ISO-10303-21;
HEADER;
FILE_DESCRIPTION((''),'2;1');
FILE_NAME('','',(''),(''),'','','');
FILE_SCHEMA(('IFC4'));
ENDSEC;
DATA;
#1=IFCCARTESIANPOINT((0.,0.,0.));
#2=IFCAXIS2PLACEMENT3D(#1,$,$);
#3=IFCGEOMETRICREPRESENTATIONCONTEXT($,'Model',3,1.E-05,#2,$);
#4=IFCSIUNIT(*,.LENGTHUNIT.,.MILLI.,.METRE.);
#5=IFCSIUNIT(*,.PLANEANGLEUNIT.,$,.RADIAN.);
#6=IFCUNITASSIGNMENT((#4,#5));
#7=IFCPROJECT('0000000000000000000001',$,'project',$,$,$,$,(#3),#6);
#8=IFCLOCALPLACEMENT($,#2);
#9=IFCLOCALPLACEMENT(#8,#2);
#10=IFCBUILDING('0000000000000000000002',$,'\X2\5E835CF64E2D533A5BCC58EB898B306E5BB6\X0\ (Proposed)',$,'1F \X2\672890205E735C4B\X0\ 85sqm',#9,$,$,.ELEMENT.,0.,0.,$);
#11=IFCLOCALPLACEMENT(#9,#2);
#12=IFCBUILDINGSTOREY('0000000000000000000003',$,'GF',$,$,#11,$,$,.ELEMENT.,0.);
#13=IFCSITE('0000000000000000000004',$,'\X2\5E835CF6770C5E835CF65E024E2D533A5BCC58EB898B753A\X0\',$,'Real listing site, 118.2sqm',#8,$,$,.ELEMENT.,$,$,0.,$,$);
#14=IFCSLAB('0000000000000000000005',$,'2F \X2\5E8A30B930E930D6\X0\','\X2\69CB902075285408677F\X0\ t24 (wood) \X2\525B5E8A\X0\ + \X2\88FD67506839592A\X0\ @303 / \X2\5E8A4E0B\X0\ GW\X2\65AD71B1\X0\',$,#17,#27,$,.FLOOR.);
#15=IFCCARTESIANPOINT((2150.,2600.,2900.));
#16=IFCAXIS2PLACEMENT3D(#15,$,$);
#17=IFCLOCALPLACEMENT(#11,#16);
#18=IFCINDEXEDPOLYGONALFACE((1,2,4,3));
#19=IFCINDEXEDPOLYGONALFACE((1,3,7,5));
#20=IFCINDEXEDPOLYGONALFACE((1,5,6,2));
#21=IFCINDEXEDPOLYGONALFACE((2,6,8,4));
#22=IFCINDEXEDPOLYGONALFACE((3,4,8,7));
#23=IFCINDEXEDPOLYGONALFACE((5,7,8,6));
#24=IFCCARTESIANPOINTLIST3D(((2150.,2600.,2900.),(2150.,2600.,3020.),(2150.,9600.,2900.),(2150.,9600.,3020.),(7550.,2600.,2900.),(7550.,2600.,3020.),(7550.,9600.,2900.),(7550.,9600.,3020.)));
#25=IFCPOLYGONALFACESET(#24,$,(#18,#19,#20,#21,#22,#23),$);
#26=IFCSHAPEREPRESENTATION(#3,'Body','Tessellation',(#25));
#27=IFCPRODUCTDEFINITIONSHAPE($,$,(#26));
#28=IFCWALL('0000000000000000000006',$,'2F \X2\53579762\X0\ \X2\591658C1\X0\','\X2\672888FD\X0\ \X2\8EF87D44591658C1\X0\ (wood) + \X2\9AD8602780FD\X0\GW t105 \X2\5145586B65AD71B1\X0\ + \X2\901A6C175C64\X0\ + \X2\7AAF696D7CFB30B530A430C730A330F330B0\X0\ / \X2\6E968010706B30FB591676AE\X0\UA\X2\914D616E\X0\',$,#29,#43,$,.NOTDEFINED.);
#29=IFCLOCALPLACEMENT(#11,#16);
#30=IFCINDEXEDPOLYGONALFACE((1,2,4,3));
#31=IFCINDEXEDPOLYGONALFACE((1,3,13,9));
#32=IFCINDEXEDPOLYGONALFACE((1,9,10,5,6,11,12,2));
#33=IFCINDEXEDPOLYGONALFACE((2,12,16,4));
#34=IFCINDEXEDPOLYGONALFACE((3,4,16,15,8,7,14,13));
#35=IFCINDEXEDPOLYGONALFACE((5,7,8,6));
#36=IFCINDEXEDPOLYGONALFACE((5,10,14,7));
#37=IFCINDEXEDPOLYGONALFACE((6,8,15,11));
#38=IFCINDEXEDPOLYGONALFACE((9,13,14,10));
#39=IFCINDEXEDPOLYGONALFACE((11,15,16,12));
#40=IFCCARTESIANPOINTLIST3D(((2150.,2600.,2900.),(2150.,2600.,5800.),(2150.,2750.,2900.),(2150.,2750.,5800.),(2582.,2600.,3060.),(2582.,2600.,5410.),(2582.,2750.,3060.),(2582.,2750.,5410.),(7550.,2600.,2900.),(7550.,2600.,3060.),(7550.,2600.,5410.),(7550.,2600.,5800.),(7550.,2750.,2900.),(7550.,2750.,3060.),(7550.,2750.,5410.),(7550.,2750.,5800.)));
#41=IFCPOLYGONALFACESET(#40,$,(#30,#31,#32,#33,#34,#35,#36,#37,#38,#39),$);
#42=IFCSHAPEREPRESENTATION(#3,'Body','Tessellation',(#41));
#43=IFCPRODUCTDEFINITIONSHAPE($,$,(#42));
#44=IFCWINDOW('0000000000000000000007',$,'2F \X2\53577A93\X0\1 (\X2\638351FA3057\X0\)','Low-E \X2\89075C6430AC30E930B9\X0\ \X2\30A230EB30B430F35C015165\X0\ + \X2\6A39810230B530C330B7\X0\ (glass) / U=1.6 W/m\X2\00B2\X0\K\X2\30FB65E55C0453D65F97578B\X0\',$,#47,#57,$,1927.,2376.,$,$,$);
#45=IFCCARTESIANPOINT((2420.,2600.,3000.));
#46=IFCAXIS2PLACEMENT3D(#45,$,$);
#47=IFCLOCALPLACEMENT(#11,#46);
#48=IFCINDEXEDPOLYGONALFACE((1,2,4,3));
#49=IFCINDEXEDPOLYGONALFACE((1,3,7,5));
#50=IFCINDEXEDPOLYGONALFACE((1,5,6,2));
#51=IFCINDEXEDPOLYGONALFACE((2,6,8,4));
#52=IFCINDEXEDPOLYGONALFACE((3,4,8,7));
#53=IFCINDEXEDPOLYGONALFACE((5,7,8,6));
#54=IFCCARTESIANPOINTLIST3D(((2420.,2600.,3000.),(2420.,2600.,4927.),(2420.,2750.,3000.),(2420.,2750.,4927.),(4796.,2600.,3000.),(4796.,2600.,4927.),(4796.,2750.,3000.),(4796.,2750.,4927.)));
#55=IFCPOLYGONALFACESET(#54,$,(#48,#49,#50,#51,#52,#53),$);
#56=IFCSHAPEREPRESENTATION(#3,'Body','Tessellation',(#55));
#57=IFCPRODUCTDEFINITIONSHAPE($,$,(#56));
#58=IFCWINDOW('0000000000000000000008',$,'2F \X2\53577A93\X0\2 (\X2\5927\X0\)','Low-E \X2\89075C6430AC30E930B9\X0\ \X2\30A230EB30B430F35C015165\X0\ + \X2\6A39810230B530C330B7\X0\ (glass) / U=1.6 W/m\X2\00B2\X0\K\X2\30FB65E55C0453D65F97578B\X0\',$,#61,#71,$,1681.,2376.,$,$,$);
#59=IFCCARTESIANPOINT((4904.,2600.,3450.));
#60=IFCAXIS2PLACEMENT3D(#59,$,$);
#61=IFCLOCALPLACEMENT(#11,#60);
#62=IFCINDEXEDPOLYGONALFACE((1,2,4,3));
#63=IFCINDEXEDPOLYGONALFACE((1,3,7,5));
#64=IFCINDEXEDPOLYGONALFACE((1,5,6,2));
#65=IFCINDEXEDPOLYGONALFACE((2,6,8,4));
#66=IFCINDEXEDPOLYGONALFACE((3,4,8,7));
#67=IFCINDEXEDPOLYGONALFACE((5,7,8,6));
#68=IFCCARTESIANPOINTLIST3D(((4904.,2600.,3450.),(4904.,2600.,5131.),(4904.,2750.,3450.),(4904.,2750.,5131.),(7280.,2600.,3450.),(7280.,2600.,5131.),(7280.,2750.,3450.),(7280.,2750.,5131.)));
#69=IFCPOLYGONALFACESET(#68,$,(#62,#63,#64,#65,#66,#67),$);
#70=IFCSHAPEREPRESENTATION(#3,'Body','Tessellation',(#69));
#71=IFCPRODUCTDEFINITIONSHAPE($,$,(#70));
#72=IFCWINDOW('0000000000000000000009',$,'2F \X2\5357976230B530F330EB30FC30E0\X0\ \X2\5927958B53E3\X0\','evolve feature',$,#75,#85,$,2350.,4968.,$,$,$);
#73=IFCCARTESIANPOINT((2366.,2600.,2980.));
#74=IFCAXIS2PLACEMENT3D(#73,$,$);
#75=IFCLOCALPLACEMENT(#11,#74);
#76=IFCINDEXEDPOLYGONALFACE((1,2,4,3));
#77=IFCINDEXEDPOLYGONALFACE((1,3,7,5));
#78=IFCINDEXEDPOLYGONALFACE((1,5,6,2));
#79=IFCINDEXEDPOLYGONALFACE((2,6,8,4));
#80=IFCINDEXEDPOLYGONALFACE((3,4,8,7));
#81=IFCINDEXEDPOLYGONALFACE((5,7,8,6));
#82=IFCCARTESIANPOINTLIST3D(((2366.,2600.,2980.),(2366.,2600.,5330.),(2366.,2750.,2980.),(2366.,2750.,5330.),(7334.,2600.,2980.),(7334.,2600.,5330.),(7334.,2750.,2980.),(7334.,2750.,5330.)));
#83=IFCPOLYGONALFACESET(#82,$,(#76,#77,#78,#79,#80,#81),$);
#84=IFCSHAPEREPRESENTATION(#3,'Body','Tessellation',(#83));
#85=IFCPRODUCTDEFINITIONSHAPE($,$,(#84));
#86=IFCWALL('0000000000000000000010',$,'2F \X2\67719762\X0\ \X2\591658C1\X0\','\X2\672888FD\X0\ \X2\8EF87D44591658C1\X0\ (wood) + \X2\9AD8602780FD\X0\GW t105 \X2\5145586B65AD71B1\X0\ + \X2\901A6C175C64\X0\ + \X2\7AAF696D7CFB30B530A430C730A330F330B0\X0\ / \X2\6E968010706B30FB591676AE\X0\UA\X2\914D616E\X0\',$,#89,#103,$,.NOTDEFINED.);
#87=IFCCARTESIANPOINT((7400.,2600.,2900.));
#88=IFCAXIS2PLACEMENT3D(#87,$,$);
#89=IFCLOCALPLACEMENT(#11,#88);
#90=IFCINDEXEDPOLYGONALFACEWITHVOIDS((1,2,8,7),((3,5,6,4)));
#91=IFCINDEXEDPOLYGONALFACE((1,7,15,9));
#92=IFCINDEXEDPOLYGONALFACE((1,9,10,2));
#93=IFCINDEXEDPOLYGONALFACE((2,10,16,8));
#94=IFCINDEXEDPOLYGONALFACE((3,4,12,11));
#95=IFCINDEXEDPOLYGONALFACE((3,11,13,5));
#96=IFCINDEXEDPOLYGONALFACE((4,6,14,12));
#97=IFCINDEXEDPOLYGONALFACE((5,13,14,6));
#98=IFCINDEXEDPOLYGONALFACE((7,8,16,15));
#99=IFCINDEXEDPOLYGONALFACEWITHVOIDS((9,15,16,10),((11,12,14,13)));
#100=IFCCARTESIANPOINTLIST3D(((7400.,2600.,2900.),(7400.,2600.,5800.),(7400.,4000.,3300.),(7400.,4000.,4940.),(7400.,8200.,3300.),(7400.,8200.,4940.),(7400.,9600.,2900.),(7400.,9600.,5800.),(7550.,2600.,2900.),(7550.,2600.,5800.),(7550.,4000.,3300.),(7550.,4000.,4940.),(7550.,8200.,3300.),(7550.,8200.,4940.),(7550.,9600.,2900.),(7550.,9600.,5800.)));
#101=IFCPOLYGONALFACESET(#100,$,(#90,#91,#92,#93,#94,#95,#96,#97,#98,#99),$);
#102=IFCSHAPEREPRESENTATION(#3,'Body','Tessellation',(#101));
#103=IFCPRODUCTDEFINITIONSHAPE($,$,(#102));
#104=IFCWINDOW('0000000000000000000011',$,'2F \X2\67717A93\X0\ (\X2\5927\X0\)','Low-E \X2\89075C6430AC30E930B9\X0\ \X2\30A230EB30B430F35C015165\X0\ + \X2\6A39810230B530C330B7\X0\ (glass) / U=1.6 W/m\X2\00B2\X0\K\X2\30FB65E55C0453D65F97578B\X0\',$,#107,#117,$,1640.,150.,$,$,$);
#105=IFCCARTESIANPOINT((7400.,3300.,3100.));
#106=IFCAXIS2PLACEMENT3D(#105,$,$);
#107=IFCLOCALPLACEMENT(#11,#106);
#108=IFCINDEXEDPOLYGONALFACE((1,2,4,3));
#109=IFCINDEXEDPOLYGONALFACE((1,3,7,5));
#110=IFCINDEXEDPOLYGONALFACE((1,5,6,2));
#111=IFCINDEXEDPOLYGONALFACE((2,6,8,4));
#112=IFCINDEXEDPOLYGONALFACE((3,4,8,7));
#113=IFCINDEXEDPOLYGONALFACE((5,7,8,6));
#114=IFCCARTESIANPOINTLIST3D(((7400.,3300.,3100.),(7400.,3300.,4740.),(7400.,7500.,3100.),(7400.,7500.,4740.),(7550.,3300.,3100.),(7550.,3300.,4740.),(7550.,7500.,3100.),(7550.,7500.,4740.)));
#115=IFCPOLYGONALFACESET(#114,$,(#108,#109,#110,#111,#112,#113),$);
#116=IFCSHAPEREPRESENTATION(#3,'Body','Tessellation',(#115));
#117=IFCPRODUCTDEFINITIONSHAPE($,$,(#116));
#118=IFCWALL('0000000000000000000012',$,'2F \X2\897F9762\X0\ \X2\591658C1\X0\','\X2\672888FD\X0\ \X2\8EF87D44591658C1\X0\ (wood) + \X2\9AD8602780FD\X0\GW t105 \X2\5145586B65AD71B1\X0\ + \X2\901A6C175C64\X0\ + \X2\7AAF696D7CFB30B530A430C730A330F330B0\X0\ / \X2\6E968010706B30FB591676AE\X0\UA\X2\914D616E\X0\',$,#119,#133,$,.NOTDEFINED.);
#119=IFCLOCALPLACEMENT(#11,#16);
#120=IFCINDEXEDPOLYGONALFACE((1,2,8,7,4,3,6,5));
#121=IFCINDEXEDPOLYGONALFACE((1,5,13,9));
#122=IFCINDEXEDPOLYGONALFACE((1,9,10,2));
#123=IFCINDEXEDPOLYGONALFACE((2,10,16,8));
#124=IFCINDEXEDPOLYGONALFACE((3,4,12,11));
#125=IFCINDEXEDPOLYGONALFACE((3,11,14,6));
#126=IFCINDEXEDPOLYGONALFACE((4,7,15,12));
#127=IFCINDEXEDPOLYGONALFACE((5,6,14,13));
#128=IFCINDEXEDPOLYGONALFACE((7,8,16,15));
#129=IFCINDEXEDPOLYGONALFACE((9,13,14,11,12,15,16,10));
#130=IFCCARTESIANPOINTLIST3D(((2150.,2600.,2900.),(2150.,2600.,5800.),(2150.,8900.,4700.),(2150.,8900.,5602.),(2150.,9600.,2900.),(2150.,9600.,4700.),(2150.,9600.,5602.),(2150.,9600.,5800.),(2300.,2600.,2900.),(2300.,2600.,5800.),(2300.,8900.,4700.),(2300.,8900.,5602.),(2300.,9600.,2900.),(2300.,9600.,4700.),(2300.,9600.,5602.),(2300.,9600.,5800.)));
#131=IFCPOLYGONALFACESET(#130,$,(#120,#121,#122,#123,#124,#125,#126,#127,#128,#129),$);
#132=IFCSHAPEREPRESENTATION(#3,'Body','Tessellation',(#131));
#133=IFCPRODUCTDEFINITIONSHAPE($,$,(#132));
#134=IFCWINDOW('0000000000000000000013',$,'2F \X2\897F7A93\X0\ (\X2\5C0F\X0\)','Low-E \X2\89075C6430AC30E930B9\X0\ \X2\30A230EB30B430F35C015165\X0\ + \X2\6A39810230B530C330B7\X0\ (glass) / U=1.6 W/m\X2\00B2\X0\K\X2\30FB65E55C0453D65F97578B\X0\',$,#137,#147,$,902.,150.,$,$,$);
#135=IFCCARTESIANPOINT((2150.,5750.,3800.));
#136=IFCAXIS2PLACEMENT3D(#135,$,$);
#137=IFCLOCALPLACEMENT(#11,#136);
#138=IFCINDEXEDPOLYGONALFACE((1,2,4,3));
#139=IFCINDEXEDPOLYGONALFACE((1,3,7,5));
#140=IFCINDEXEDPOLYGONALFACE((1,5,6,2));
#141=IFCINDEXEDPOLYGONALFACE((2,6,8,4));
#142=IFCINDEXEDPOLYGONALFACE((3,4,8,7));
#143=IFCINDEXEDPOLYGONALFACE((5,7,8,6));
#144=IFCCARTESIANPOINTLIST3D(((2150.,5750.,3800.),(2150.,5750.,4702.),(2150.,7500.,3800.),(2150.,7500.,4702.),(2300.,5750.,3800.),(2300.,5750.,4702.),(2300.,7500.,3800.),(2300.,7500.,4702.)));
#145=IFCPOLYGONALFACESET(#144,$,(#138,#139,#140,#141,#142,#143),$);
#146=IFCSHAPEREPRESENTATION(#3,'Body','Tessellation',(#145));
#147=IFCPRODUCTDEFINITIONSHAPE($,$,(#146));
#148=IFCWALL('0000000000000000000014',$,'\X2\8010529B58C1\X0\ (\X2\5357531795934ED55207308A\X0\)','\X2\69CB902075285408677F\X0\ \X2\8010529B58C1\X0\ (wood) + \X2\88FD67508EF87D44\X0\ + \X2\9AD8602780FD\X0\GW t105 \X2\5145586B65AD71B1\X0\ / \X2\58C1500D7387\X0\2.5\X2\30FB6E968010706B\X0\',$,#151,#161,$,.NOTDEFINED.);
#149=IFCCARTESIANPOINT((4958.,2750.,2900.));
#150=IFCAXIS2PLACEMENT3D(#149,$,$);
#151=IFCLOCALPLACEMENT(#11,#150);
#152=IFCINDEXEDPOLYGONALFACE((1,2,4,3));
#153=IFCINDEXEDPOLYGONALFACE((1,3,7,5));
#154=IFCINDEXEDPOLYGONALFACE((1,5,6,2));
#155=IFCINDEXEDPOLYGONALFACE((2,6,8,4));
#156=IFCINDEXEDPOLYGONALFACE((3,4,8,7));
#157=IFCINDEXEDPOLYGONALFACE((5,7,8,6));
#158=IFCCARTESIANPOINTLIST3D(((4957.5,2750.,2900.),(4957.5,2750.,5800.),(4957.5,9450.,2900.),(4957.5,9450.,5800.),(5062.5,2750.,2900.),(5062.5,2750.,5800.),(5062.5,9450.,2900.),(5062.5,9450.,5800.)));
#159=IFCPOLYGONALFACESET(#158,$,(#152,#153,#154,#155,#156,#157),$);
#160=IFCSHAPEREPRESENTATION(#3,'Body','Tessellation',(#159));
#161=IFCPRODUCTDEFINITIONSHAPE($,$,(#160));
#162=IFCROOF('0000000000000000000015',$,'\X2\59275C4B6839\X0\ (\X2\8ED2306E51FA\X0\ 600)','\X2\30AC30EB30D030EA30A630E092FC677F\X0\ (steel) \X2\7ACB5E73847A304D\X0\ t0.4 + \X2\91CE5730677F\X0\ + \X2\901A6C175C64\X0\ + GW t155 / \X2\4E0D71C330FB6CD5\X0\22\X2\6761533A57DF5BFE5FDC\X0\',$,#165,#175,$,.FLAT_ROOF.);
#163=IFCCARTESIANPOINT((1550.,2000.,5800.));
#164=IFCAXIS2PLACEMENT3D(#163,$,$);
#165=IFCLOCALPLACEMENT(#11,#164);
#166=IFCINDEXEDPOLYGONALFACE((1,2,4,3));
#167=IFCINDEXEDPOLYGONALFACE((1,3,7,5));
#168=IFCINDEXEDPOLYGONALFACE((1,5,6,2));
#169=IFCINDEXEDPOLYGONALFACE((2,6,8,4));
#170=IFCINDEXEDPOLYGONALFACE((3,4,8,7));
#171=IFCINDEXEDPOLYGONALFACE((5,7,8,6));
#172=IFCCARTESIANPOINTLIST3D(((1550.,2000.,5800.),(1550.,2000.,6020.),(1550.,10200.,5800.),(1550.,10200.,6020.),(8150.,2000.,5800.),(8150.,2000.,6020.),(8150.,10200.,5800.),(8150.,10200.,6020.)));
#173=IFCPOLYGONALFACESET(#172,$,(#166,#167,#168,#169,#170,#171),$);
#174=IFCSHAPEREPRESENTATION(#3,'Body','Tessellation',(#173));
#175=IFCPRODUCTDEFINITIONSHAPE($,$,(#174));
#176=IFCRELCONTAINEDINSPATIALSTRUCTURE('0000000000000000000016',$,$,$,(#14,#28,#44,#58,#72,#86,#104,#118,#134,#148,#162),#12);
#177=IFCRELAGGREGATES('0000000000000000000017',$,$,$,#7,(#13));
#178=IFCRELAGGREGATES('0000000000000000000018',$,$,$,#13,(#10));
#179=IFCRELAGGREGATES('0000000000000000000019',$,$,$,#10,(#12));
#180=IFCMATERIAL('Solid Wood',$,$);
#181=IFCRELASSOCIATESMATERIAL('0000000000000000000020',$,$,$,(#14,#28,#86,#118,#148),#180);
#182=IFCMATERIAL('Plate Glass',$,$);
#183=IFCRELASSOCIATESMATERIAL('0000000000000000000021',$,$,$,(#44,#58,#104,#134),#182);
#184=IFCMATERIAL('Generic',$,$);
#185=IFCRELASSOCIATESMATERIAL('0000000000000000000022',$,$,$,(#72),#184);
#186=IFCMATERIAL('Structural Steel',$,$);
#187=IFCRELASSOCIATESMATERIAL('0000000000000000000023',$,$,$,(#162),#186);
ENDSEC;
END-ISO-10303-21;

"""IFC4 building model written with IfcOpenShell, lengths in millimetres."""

from ifc_helpers import new_model, si_unit, frame, frame_2d, origin, place, context, project, spatial, rectangle, extrude, material, element, fill, save


model = new_model("IFC4")

# Units and contexts
model_context = context("Model", 3, precision=1e-05, world=origin())
ifc_project = project(units=[si_unit("LENGTHUNIT", "METRE", prefix="MILLI"), si_unit("PLANEANGLEUNIT", "RADIAN")], contexts=[model_context])

# Site, building, storey
site_placement = place(None, origin())
site = spatial("IfcSite", under=ifc_project, at=site_placement, Name="広島県広島市中区富士見町", ObjectType="Real listing site, 118.2sqm", CompositionType="ELEMENT", RefElevation=0.0)
building_placement = place(site_placement, origin())
building = spatial("IfcBuilding", under=site, at=building_placement, Name="広島中区富士見の家 (Proposed)", ObjectType="1F 木造平屋 85sqm", CompositionType="ELEMENT", ElevationOfRefHeight=0.0, ElevationOfTerrain=0.0)
storey_placement = place(building_placement, origin())
storey = spatial("IfcBuildingStorey", under=building, at=storey_placement, Name="GF", CompositionType="ELEMENT", Elevation=0.0)

# Slab
ifc_material_1 = material(Name="Solid Wood")
slab_placement = place(storey_placement, frame((2150.0, 2600.0, 2900.0)))
element("IfcSlab", 1, at=slab_placement, inside=storey, material=ifc_material_1, Name="2F 床スラブ", Description="構造用合板 t24 (wood) 剛床 + 製材根太 @303 / 床下 GW断熱", PredefinedType="FLOOR", context=model_context, shape_type="SweptSolid", body=[
    extrude(rectangle(XDim=5400.0, YDim=7000.0, at=frame_2d((2700.0, 3500.0))), frame((2150.0, 2600.0, 2900.0)), (0.0, 0.0, 1.0), 120.0),
])

# Wall, openings, windows
wall_1_placement = place(storey_placement, frame((2150.0, 2600.0, 2900.0)))
wall_1 = element("IfcWall", 2, at=wall_1_placement, inside=storey, material=ifc_material_1, Name="2F 南面 外壁", Description="木製 軸組外壁 (wood) + 高性能GW t105 充填断熱 + 通気層 + 窯業系サイディング / 準耐火・外皮UA配慮", PredefinedType="NOTDEFINED", context=model_context, shape_type="SweptSolid", body=[
    extrude(rectangle(XDim=5400.0, YDim=150.0, at=frame_2d((2700.0, 75.0))), frame((2150.0, 2600.0, 2900.0)), (0.0, 0.0, 1.0), 2900.0),
])
opening_1_placement = place(storey_placement, frame((2420.0, 2600.0, 3000.0)))
opening_1 = element("IfcOpeningElement", 3, at=opening_1_placement, cuts=wall_1, PredefinedType="NOTDEFINED", context=model_context, shape_type="SweptSolid", body=[
    extrude(rectangle(XDim=2376.0, YDim=150.0, at=frame_2d((1188.0, 75.0))), frame((2420.0, 2600.0, 3000.0)), (0.0, 0.0, 1.0), 1927.0),
])
opening_2_placement = place(storey_placement, frame((4904.0, 2600.0, 3450.0)))
opening_2 = element("IfcOpeningElement", 4, at=opening_2_placement, cuts=wall_1, PredefinedType="NOTDEFINED", context=model_context, shape_type="SweptSolid", body=[
    extrude(rectangle(XDim=2376.0, YDim=150.0, at=frame_2d((1188.0, 75.0))), frame((4904.0, 2600.0, 3450.0)), (0.0, 0.0, 1.0), 1681.0),
])
opening_3_placement = place(storey_placement, frame((2366.0, 2600.0, 2980.0)))
opening_3 = element("IfcOpeningElement", 5, at=opening_3_placement, cuts=wall_1, PredefinedType="NOTDEFINED", context=model_context, shape_type="SweptSolid", body=[
    extrude(rectangle(XDim=4968.0, YDim=150.0, at=frame_2d((2484.0, 75.0))), frame((2366.0, 2600.0, 2980.0)), (0.0, 0.0, 1.0), 2350.0),
])
ifc_material_2 = material(Name="Plate Glass")
window_1_placement = place(storey_placement, frame((2420.0, 2600.0, 3000.0)))
window_1 = element("IfcWindow", 6, at=window_1_placement, inside=storey, material=ifc_material_2, Name="2F 南窓1 (掃出し)", Description="Low-E 複層ガラス アルゴン封入 + 樹脂サッシ (glass) / U=1.6 W/m²K・日射取得型", OverallHeight=1927.0, OverallWidth=2376.0, context=model_context, shape_type="SweptSolid", body=[
    extrude(rectangle(XDim=2376.0, YDim=150.0, at=frame_2d((1188.0, 75.0))), frame((2420.0, 2600.0, 3000.0)), (0.0, 0.0, 1.0), 1927.0),
])
fill(opening_1, window_1)
window_2_placement = place(storey_placement, frame((4904.0, 2600.0, 3450.0)))
window_2 = element("IfcWindow", 7, at=window_2_placement, inside=storey, material=ifc_material_2, Name="2F 南窓2 (大)", Description="Low-E 複層ガラス アルゴン封入 + 樹脂サッシ (glass) / U=1.6 W/m²K・日射取得型", OverallHeight=1681.0, OverallWidth=2376.0, context=model_context, shape_type="SweptSolid", body=[
    extrude(rectangle(XDim=2376.0, YDim=150.0, at=frame_2d((1188.0, 75.0))), frame((4904.0, 2600.0, 3450.0)), (0.0, 0.0, 1.0), 1681.0),
])
fill(opening_2, window_2)
ifc_material_3 = material(Name="Generic")
window_3_placement = place(storey_placement, frame((2366.0, 2600.0, 2980.0)))
window_3 = element("IfcWindow", 8, at=window_3_placement, inside=storey, material=ifc_material_3, Name="2F 南面サンルーム 大開口", Description="evolve feature", OverallHeight=2350.0, OverallWidth=4968.0, context=model_context, shape_type="SweptSolid", body=[
    extrude(rectangle(XDim=4968.0, YDim=150.0, at=frame_2d((2484.0, 75.0))), frame((2366.0, 2600.0, 2980.0)), (0.0, 0.0, 1.0), 2350.0),
])
fill(opening_3, window_3)

# Walls, openings, windows
wall_2_placement = place(storey_placement, frame((7400.0, 2600.0, 2900.0)))
wall_2 = element("IfcWall", 9, at=wall_2_placement, inside=storey, material=ifc_material_1, Name="2F 東面 外壁", Description="木製 軸組外壁 (wood) + 高性能GW t105 充填断熱 + 通気層 + 窯業系サイディング / 準耐火・外皮UA配慮", PredefinedType="NOTDEFINED", context=model_context, shape_type="SweptSolid", body=[
    extrude(rectangle(XDim=150.0, YDim=7000.0, at=frame_2d((75.0, 3500.0))), frame((7400.0, 2600.0, 2900.0)), (0.0, 0.0, 1.0), 2900.0),
])
opening_4_placement = place(storey_placement, frame((7400.0, 3300.0, 3100.0)))
opening_4 = element("IfcOpeningElement", 10, at=opening_4_placement, cuts=wall_2, PredefinedType="NOTDEFINED", context=model_context, shape_type="SweptSolid", body=[
    extrude(rectangle(XDim=150.0, YDim=4200.0, at=frame_2d((75.0, 2100.0))), frame((7400.0, 3300.0, 3100.0)), (0.0, 0.0, 1.0), 1640.0),
])
window_4_placement = place(storey_placement, frame((7400.0, 3300.0, 3100.0)))
window_4 = element("IfcWindow", 11, at=window_4_placement, inside=storey, material=ifc_material_2, Name="2F 東窓 (大)", Description="Low-E 複層ガラス アルゴン封入 + 樹脂サッシ (glass) / U=1.6 W/m²K・日射取得型", OverallHeight=1640.0, OverallWidth=150.0, context=model_context, shape_type="SweptSolid", body=[
    extrude(rectangle(XDim=150.0, YDim=4200.0, at=frame_2d((75.0, 2100.0))), frame((7400.0, 3300.0, 3100.0)), (0.0, 0.0, 1.0), 1640.0),
])
fill(opening_4, window_4)
wall_3_placement = place(storey_placement, frame((2150.0, 2600.0, 2900.0)))
wall_3 = element("IfcWall", 12, at=wall_3_placement, inside=storey, material=ifc_material_1, Name="2F 西面 外壁", Description="木製 軸組外壁 (wood) + 高性能GW t105 充填断熱 + 通気層 + 窯業系サイディング / 準耐火・外皮UA配慮", PredefinedType="NOTDEFINED", context=model_context, shape_type="SweptSolid", body=[
    extrude(rectangle(XDim=150.0, YDim=7000.0, at=frame_2d((75.0, 3500.0))), frame((2150.0, 2600.0, 2900.0)), (0.0, 0.0, 1.0), 2900.0),
])
opening_5_placement = place(storey_placement, frame((2150.0, 5750.0, 3800.0)))
opening_5 = element("IfcOpeningElement", 13, at=opening_5_placement, cuts=wall_3, PredefinedType="NOTDEFINED", context=model_context, shape_type="SweptSolid", body=[
    extrude(rectangle(XDim=150.0, YDim=1750.0, at=frame_2d((75.0, 875.0))), frame((2150.0, 5750.0, 3800.0)), (0.0, 0.0, 1.0), 902.0),
])
window_5_placement = place(storey_placement, frame((2150.0, 5750.0, 3800.0)))
window_5 = element("IfcWindow", 14, at=window_5_placement, inside=storey, material=ifc_material_2, Name="2F 西窓 (小)", Description="Low-E 複層ガラス アルゴン封入 + 樹脂サッシ (glass) / U=1.6 W/m²K・日射取得型", OverallHeight=902.0, OverallWidth=150.0, context=model_context, shape_type="SweptSolid", body=[
    extrude(rectangle(XDim=150.0, YDim=1750.0, at=frame_2d((75.0, 875.0))), frame((2150.0, 5750.0, 3800.0)), (0.0, 0.0, 1.0), 902.0),
])
fill(opening_5, window_5)

# Wall
wall_4_placement = place(storey_placement, frame((4958.0, 2750.0, 2900.0)))
element("IfcWall", 15, at=wall_4_placement, inside=storey, material=ifc_material_1, Name="耐力壁 (南北間仕切り)", Description="構造用合板 耐力壁 (wood) + 製材軸組 + 高性能GW t105 充填断熱 / 壁倍率2.5・準耐火", PredefinedType="NOTDEFINED", context=model_context, shape_type="SweptSolid", body=[
    extrude(rectangle(XDim=105.0, YDim=6700.0, at=frame_2d((52.0, 3350.0))), frame((4958.0, 2750.0, 2900.0)), (0.0, 0.0, 1.0), 2900.0),
])

# Roof
ifc_material_4 = material(Name="Structural Steel")
roof_1_placement = place(storey_placement, frame((1550.0, 2000.0, 5800.0)))
element("IfcRoof", 16, at=roof_1_placement, inside=storey, material=ifc_material_4, Name="大屋根 (軒の出 600)", Description="ガルバリウム鋼板 (steel) 立平葺き t0.4 + 野地板 + 通気層 + GW t155 / 不燃・法22条区域対応", PredefinedType="FLAT_ROOF", context=model_context, shape_type="SweptSolid", body=[
    extrude(rectangle(XDim=6600.0, YDim=8200.0, at=frame_2d((3300.0, 4100.0))), frame((1550.0, 2000.0, 5800.0)), (0.0, 0.0, 1.0), 220.0),
])

save(model, "model.ifc")
